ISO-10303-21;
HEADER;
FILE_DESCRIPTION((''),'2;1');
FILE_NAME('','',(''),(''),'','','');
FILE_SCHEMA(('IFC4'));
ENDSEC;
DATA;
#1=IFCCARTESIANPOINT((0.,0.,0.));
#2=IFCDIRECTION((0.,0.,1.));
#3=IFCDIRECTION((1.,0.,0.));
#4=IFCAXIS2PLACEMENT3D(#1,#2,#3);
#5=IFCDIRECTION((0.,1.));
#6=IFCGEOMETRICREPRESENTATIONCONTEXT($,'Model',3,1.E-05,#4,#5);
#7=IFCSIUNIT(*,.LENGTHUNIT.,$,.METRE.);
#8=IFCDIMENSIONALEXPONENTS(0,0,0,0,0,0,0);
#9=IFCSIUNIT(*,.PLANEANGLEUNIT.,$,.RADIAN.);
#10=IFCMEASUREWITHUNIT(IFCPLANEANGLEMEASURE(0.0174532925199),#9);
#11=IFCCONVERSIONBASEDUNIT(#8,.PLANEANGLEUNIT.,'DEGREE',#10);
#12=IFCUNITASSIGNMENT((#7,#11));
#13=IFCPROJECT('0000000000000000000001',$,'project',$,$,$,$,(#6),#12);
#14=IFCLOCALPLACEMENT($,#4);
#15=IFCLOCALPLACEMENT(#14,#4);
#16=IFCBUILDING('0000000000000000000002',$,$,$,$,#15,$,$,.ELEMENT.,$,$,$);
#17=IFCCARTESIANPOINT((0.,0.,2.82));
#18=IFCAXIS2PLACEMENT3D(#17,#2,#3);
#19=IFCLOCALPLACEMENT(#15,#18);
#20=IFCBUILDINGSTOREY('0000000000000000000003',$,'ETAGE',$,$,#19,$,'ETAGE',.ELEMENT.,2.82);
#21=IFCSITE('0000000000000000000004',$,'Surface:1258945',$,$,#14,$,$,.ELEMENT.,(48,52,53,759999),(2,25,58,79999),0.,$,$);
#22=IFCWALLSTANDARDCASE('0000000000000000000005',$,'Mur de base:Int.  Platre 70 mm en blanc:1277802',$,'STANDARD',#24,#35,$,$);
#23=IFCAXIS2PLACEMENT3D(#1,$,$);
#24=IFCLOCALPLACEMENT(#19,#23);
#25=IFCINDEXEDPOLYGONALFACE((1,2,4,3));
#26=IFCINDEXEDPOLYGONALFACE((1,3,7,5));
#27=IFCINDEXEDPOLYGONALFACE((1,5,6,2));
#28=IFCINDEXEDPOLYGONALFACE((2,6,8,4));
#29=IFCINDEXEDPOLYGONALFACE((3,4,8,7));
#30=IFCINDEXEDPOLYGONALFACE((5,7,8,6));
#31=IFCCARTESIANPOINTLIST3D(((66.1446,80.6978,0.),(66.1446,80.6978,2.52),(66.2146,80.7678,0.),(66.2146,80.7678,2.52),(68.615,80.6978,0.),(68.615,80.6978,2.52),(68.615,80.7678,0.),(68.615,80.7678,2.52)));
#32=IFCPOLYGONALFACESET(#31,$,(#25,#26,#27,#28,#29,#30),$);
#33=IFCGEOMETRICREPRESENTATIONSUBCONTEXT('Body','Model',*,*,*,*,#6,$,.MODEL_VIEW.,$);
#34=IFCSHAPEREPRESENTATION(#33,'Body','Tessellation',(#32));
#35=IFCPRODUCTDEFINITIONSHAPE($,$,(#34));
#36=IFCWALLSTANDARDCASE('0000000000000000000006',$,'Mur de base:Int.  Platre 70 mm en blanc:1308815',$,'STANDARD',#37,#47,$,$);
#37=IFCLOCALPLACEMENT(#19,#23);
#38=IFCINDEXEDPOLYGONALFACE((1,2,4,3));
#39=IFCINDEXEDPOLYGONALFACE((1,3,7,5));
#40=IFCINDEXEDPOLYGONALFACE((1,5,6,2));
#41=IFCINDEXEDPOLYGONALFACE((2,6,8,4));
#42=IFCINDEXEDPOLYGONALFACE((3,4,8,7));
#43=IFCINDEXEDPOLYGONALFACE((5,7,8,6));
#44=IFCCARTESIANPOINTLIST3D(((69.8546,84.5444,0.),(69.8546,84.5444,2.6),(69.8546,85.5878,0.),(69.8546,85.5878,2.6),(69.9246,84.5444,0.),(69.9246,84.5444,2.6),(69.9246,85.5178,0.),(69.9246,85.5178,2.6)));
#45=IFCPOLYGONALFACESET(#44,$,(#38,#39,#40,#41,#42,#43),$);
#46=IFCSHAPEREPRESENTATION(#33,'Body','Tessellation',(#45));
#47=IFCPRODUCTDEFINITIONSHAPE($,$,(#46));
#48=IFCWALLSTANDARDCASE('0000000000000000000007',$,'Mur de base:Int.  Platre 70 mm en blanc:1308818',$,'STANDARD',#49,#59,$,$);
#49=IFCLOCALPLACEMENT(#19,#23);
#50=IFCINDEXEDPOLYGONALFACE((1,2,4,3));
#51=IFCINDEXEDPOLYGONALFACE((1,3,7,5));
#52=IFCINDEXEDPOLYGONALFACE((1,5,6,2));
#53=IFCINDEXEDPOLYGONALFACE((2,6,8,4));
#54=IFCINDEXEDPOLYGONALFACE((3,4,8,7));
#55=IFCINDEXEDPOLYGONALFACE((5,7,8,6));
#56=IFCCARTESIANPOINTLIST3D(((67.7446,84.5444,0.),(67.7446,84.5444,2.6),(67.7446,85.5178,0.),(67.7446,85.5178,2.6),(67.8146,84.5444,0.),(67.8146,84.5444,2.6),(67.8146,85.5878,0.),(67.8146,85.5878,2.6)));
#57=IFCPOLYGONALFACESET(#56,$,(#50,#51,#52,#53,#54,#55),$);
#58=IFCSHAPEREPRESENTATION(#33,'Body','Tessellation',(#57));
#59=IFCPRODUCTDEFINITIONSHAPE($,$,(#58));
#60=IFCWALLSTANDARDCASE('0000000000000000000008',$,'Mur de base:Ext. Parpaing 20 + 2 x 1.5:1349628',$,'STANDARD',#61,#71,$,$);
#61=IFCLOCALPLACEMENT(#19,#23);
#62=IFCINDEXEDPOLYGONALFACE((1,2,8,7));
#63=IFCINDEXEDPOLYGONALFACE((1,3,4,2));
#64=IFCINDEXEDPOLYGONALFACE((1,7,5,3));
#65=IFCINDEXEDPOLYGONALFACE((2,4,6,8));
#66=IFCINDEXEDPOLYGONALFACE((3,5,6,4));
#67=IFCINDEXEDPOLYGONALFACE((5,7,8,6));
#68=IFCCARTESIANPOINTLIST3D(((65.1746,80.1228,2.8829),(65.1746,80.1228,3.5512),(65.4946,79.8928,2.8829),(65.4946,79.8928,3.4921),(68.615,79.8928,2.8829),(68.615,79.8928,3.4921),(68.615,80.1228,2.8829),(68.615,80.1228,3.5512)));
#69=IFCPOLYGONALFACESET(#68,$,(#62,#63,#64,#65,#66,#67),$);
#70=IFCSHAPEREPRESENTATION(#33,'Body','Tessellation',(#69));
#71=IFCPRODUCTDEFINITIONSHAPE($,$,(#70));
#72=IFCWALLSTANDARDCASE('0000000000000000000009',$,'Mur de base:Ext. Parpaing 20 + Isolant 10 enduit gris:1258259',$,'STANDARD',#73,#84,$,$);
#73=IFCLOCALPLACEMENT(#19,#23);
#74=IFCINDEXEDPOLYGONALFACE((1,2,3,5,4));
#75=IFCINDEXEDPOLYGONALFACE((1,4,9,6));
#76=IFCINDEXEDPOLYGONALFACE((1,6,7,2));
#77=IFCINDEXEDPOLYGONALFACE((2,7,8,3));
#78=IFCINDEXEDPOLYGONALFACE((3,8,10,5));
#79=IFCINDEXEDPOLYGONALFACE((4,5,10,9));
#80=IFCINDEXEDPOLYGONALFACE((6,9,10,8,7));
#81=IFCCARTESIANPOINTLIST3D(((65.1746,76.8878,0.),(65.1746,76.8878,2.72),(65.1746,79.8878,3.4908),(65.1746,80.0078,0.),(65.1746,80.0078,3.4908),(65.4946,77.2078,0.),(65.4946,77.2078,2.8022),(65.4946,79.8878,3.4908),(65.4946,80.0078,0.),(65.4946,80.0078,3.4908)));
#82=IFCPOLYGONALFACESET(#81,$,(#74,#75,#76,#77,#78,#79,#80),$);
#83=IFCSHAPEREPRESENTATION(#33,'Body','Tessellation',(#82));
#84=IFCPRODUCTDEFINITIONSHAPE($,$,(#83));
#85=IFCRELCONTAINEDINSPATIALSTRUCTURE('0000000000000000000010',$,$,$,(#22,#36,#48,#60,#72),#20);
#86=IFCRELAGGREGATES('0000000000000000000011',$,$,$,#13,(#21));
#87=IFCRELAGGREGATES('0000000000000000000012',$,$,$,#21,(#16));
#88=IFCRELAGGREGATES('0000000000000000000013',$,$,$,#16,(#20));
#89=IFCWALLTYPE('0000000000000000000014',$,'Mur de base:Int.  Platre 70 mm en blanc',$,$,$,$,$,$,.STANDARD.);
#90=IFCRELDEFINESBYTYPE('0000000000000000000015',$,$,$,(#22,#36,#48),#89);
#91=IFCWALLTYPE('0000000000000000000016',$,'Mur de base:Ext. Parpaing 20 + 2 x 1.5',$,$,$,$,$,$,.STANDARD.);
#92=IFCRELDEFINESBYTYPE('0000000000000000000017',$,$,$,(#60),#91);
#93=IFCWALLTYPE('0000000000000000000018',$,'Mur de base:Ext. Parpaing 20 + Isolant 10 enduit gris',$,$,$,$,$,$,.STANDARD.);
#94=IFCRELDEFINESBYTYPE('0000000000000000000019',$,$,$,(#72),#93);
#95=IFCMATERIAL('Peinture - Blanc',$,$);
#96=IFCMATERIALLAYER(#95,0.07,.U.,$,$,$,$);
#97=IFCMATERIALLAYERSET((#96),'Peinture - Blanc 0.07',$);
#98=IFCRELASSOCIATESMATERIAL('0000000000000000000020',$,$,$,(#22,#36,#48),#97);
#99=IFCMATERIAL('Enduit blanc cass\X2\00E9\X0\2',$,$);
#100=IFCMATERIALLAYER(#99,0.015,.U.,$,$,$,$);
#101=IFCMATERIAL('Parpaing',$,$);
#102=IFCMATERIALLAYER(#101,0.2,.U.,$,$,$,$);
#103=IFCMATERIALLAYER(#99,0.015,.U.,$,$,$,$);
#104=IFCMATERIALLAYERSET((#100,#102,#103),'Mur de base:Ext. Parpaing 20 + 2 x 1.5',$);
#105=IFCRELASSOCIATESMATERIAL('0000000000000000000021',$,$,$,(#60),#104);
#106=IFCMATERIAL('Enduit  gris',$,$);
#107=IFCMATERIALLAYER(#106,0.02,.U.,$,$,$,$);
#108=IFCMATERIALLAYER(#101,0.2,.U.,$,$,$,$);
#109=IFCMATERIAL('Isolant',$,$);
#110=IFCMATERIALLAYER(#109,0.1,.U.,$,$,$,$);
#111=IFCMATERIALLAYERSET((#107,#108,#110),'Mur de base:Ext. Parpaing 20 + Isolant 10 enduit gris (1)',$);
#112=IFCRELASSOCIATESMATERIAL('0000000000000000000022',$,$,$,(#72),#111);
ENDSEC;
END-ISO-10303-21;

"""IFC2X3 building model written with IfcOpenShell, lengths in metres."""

from ifc_helpers import new_model, entity, si_unit, converted_unit, direction, frame, origin_with_axes, place, context, subcontext, project, spatial, polyline, outline, extrude, clip, halfspace, material, layer, layer_set, layer_usage, type_object, element, save


model = new_model("IFC2X3")

# Units and contexts
model_context = context("Model", 3, precision=1e-05, world=origin_with_axes(), true_north=direction((0.0, 1.0)))
body_context = subcontext(model_context, "Body", "Model", "MODEL_VIEW")
ifc_project = project(units=[si_unit("LENGTHUNIT", "METRE"), converted_unit("PLANEANGLEUNIT", "DEGREE", entity("IfcPlaneAngleMeasure", 0.0174532925199), si_unit("PLANEANGLEUNIT", "RADIAN"), dimensions=[0, 0, 0, 0, 0, 0, 0])], contexts=[model_context])

# Site, building, storey
site_placement = place(None, origin_with_axes())
site = spatial("IfcSite", under=ifc_project, at=site_placement, Name="Surface:1258945", CompositionType="ELEMENT", RefLatitude=(48, 52, 53, 759999), RefLongitude=(2, 25, 58, 79999), RefElevation=0.0)
building_placement = place(site_placement, origin_with_axes())
building = spatial("IfcBuilding", under=site, at=building_placement, CompositionType="ELEMENT")
storey_placement = place(building_placement, frame((0.0, 0.0, 2.82), z_axis=(0.0, 0.0, 1.0), x_axis=(1.0, 0.0, 0.0)))
storey = spatial("IfcBuildingStorey", under=building, at=storey_placement, Name="ETAGE", LongName="ETAGE", CompositionType="ELEMENT", Elevation=2.82)

# Shared definitions
ifc_material_1 = material(Name="Enduit blanc cassé2")
ifc_material_2 = material(Name="Parpaing")
ifc_material_3 = material(Name="Isolant")
ifc_material_4 = material(Name="Peinture - Blanc")
ifc_layer_1 = layer(ifc_material_4, 0.07, ventilated="UNKNOWN")
ifc_layer_set_1 = layer_set([ifc_layer_1], Name="Peinture - Blanc 0.07")
wall_type_1 = type_object("IfcWallType", Name="Mur de base:Int.  Platre 70 mm en blanc", PredefinedType="STANDARD")

# Walls
ifc_layer_usage_1 = layer_usage(ifc_layer_set_1, "AXIS2", "POSITIVE", -0.035)
wall_1_placement = place(storey_placement, frame((66.1796, 80.7328, 0.0), z_axis=(0.0, 0.0, 1.0), x_axis=(1.0, 0.0, 0.0)))
element("IfcWallStandardCase", 1, at=wall_1_placement, inside=storey, type_object=wall_type_1, material=ifc_layer_usage_1, Name="Mur de base:Int.  Platre 70 mm en blanc:1277802", ObjectType="STANDARD", context=body_context, shape_type="SweptSolid", body=[
    extrude(outline(polyline([(-0.035, -0.035), (2.4354, -0.035), (2.4354, 0.035), (0.035, 0.035), (-0.035, -0.035)])), origin_with_axes(), (0.0, 0.0, 1.0), 2.52),
])
ifc_layer_usage_2 = layer_usage(ifc_layer_set_1, "AXIS2", "POSITIVE", -0.035)
wall_2_placement = place(storey_placement, frame((69.8896, 84.5094, 0.0), z_axis=(0.0, 0.0, 1.0), x_axis=(0.0, 1.0, 0.0)))
element("IfcWallStandardCase", 2, at=wall_2_placement, inside=storey, type_object=wall_type_1, material=ifc_layer_usage_2, Name="Mur de base:Int.  Platre 70 mm en blanc:1308815", ObjectType="STANDARD", context=body_context, shape_type="SweptSolid", body=[
    extrude(outline(polyline([(0.035, -0.035), (1.0083, -0.035), (1.0783, 0.035), (0.035, 0.035), (0.035, -0.035)])), origin_with_axes(), (0.0, 0.0, 1.0), 2.6),
])
ifc_layer_usage_3 = layer_usage(ifc_layer_set_1, "AXIS2", "POSITIVE", -0.035)
wall_3_placement = place(storey_placement, frame((67.7796, 84.5094, 0.0), z_axis=(0.0, 0.0, 1.0), x_axis=(0.0, 1.0, 0.0)))
element("IfcWallStandardCase", 3, at=wall_3_placement, inside=storey, type_object=wall_type_1, material=ifc_layer_usage_3, Name="Mur de base:Int.  Platre 70 mm en blanc:1308818", ObjectType="STANDARD", context=body_context, shape_type="SweptSolid", body=[
    extrude(outline(polyline([(0.035, -0.035), (1.0783, -0.035), (1.0083, 0.035), (0.035, 0.035), (0.035, -0.035)])), origin_with_axes(), (0.0, 0.0, 1.0), 2.6),
])
ifc_layer_2 = layer(ifc_material_1, 0.015, ventilated="UNKNOWN")
ifc_layer_3 = layer(ifc_material_2, 0.2, ventilated="UNKNOWN")
ifc_layer_4 = layer(ifc_material_1, 0.015, ventilated="UNKNOWN")
ifc_layer_set_2 = layer_set([ifc_layer_2, ifc_layer_3, ifc_layer_4], Name="Mur de base:Ext. Parpaing 20 + 2 x 1.5")
ifc_layer_usage_4 = layer_usage(ifc_layer_set_2, "AXIS2", "POSITIVE", -0.115)
wall_type_2 = type_object("IfcWallType", Name="Mur de base:Ext. Parpaing 20 + 2 x 1.5", PredefinedType="STANDARD")
wall_4_placement = place(storey_placement, frame((65.3346, 80.0078, 2.8829), z_axis=(0.0, 0.0, 1.0), x_axis=(1.0, 0.0, 0.0)))
element("IfcWallStandardCase", 4, at=wall_4_placement, inside=storey, type_object=wall_type_2, material=ifc_layer_usage_4, Name="Mur de base:Ext. Parpaing 20 + 2 x 1.5:1349628", ObjectType="STANDARD", context=body_context, shape_type="Clipping", body=[
    clip(extrude(outline(polyline([(0.16, -0.115), (3.2804, -0.115), (3.2804, 0.115), (-0.16, 0.115), (0.16, -0.115)])), origin_with_axes(), (0.0, 0.0, 1.0), 0.6683), halfspace(frame((0.0, -0.154, 0.5992), z_axis=(0.0, 0.248865, -0.968538), x_axis=(0.0, 0.968538, 0.248865)), True)),
])
ifc_material_5 = material(Name="Enduit  gris")
ifc_layer_5 = layer(ifc_material_5, 0.02, ventilated="UNKNOWN")
ifc_layer_6 = layer(ifc_material_2, 0.2, ventilated="UNKNOWN")
ifc_layer_7 = layer(ifc_material_3, 0.1, ventilated="UNKNOWN")
ifc_layer_set_3 = layer_set([ifc_layer_5, ifc_layer_6, ifc_layer_7], Name="Mur de base:Ext. Parpaing 20 + Isolant 10 enduit gris (1)")
ifc_layer_usage_5 = layer_usage(ifc_layer_set_3, "AXIS2", "POSITIVE", -0.16)
wall_type_3 = type_object("IfcWallType", Name="Mur de base:Ext. Parpaing 20 + Isolant 10 enduit gris", PredefinedType="STANDARD")
wall_5_placement = place(storey_placement, frame((65.3346, 80.0078, 0.0), z_axis=(0.0, 0.0, 1.0), x_axis=(0.0, -1.0, 0.0)))
element("IfcWallStandardCase", 5, at=wall_5_placement, inside=storey, type_object=wall_type_3, material=ifc_layer_usage_5, Name="Mur de base:Ext. Parpaing 20 + Isolant 10 enduit gris:1258259", ObjectType="STANDARD", context=body_context, shape_type="Clipping", body=[
    clip(extrude(outline(polyline([(0.0, -0.16), (3.12, -0.16), (2.8, 0.16), (0.0, 0.16), (0.0, -0.16)])), origin_with_axes(), (0.0, 0.0, 1.0), 3.4908), halfspace(frame((0.8488, 0.0, 3.3036), z_axis=(-0.248865, 0.0, -0.968538), x_axis=(0.0, 1.0, 0.0)), True)),
])

save(model, "model.ifc")
